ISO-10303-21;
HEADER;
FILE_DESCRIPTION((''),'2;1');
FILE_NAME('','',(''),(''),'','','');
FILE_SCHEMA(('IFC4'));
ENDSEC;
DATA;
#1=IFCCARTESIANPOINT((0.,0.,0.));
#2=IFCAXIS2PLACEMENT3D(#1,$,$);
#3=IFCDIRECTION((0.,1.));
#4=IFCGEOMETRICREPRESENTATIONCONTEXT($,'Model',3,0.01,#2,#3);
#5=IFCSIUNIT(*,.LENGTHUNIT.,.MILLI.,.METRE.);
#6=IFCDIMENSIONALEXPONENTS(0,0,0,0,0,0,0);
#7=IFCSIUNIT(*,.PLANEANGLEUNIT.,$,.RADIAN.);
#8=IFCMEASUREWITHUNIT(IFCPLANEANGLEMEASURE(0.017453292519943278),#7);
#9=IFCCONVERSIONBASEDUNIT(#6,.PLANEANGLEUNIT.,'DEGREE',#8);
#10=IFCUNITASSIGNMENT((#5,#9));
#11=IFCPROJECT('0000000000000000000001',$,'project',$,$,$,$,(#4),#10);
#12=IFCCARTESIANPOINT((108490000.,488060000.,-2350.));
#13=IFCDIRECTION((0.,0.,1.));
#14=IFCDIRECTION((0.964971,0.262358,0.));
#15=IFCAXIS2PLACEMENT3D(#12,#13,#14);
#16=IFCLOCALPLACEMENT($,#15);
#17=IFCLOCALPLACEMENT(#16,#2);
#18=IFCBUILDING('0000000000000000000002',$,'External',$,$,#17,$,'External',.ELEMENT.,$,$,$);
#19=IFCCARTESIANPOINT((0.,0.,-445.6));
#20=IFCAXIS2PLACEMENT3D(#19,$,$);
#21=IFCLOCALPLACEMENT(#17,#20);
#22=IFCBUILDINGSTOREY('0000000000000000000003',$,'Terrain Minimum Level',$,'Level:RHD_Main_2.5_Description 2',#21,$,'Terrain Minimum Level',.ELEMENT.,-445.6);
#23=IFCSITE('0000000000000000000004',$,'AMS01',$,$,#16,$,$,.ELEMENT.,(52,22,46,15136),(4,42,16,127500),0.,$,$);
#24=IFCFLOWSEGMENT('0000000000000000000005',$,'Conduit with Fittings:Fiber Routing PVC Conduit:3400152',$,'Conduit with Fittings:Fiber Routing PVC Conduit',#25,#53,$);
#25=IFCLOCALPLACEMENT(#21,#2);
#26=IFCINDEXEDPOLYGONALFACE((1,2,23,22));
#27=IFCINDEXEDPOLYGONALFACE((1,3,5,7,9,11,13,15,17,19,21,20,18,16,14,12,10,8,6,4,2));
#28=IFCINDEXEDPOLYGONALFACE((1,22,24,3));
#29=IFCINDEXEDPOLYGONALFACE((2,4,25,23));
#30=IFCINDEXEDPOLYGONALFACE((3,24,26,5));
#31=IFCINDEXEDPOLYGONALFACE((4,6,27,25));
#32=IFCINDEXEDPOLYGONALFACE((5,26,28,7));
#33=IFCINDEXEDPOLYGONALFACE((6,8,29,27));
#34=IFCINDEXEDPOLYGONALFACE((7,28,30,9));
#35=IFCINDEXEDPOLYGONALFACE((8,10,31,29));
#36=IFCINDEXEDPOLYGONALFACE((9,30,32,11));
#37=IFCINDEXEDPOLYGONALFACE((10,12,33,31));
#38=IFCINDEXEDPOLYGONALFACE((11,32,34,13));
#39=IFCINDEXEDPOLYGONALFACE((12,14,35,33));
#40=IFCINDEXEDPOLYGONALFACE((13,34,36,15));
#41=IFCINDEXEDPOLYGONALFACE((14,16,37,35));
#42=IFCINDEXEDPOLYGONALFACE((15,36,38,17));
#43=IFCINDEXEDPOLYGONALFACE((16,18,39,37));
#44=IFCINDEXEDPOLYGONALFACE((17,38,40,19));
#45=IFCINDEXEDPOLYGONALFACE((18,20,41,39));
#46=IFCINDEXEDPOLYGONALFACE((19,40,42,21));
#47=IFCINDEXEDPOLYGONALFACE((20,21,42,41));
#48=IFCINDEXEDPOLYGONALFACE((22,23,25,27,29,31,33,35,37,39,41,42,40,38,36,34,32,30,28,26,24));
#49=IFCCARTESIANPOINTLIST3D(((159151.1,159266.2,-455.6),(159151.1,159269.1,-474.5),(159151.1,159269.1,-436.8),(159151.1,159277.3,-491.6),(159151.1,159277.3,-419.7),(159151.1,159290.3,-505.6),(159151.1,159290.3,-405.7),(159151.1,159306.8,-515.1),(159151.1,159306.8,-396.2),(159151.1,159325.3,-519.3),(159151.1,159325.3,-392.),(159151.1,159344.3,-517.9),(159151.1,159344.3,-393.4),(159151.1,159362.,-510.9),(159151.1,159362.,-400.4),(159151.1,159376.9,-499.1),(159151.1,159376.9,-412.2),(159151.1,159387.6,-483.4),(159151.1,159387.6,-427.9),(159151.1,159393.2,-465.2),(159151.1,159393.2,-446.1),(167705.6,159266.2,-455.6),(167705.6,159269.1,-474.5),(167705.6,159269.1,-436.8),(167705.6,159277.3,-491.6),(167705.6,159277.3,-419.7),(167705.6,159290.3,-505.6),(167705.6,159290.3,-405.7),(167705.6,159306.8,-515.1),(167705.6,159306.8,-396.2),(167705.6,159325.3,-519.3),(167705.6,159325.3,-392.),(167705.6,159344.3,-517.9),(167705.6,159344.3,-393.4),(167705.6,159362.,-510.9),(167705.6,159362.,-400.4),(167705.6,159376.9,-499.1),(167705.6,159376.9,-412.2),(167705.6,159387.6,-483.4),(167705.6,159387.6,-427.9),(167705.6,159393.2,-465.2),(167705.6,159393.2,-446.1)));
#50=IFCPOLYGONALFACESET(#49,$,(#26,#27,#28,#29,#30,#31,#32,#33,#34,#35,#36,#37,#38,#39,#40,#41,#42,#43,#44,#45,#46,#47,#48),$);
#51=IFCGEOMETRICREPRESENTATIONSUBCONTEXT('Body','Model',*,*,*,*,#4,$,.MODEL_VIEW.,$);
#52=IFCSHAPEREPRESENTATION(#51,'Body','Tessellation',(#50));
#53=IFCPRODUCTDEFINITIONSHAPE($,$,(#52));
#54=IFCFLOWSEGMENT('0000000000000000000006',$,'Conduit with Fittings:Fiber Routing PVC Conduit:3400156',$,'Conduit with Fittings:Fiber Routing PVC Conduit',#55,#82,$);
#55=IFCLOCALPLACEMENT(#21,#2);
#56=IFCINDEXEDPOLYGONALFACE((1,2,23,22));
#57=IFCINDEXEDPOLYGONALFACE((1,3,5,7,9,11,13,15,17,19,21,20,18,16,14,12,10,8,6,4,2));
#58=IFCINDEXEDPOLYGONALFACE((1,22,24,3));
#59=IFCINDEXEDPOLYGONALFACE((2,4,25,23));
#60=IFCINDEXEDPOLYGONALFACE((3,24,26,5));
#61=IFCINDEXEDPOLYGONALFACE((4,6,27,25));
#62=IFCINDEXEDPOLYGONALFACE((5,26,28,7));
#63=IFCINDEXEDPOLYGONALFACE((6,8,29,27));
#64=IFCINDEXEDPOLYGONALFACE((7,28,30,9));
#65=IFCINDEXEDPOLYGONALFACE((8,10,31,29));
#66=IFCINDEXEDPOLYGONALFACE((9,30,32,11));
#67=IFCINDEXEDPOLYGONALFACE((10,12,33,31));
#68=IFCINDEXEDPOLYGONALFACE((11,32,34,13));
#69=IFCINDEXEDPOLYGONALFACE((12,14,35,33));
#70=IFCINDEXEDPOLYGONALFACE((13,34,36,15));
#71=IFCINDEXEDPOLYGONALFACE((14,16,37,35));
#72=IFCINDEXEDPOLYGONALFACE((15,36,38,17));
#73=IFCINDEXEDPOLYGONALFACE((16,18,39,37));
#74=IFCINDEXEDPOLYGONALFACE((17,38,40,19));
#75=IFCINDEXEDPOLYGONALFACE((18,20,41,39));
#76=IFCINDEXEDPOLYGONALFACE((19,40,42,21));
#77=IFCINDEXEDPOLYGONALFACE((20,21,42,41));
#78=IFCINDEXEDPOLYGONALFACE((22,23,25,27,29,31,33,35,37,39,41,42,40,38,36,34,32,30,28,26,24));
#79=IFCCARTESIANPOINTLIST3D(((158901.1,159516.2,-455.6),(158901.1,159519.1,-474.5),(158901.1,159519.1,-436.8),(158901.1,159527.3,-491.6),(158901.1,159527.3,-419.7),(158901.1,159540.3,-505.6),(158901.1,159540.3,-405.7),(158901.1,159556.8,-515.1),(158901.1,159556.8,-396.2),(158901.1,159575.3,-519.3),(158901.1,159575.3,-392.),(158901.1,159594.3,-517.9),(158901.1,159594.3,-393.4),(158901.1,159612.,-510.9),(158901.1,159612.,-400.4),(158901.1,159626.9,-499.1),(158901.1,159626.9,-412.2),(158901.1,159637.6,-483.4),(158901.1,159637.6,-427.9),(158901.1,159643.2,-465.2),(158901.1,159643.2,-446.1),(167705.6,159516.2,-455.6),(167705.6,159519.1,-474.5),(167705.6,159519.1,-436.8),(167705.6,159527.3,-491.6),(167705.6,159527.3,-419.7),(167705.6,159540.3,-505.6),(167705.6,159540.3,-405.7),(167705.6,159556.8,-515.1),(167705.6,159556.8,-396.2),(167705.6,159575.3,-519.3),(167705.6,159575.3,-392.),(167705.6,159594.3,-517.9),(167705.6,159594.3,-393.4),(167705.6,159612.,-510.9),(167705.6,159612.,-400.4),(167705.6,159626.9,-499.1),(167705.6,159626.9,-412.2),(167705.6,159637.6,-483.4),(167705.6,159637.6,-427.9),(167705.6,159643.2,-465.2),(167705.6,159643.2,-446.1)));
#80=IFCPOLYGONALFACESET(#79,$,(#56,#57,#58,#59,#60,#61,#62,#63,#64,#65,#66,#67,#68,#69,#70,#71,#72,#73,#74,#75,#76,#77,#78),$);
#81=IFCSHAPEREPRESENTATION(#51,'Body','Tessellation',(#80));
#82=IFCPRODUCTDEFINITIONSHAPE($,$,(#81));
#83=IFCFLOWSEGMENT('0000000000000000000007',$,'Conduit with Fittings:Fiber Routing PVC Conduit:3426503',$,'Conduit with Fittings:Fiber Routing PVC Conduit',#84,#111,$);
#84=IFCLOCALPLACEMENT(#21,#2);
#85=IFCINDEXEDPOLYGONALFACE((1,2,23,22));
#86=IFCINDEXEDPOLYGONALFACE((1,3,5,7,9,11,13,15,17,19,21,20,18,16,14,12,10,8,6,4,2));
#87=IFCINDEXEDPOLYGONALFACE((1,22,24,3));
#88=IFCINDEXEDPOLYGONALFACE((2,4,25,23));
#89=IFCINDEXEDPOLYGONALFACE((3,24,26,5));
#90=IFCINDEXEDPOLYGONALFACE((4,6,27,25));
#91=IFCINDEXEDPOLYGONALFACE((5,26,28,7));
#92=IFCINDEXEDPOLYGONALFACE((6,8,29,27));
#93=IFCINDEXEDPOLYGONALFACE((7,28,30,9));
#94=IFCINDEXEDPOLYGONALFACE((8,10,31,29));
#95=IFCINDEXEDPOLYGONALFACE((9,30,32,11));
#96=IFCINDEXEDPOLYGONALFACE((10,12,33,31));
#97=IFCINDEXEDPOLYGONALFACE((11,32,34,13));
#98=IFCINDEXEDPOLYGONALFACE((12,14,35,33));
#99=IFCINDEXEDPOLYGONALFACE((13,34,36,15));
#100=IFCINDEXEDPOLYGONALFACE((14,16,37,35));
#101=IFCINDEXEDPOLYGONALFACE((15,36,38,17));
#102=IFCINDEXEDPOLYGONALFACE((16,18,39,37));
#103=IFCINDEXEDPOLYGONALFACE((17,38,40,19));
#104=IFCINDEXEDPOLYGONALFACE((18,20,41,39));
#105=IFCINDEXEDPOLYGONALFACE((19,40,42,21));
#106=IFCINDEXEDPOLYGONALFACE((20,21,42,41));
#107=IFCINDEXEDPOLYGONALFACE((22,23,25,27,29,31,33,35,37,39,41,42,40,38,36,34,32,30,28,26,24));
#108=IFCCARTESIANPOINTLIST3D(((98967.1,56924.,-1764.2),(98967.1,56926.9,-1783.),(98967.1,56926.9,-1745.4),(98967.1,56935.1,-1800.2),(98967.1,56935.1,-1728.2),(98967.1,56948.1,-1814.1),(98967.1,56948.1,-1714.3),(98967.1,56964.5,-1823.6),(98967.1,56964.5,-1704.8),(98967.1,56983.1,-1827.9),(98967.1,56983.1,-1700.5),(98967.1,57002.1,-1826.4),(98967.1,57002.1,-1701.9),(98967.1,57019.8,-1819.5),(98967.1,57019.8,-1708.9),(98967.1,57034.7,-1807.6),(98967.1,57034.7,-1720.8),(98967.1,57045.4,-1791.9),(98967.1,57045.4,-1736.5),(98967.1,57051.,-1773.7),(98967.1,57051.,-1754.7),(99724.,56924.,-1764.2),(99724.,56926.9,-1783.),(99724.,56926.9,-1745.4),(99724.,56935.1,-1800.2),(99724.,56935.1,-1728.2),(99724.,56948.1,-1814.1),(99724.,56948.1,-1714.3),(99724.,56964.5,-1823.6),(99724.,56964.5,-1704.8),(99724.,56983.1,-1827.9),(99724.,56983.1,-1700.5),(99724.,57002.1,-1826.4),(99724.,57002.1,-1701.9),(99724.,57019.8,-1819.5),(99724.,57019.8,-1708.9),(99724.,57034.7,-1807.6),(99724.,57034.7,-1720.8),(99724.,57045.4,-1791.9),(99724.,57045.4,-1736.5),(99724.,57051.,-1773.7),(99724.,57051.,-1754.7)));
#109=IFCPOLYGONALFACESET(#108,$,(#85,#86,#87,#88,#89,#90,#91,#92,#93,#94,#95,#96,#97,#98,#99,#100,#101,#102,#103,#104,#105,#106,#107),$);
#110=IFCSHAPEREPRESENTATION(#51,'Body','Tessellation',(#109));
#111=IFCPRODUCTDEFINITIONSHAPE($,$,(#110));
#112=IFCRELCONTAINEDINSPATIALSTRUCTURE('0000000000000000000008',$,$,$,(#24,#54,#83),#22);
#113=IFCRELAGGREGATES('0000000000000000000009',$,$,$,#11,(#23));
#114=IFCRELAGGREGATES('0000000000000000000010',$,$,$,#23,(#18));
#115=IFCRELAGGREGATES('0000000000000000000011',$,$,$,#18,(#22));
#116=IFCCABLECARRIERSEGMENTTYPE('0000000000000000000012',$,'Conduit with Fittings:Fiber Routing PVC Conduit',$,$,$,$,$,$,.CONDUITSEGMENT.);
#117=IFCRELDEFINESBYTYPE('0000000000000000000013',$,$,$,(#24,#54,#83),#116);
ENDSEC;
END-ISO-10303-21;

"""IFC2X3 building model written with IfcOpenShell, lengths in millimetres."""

from ifc_helpers import new_model, entity, si_unit, converted_unit, direction, frame, origin, origin_2d_with_axis, place, context, subcontext, project, spatial, circle, extrude, type_object, element, save


model = new_model("IFC2X3")

# Units and contexts
model_context = context("Model", 3, precision=0.01, world=origin(), true_north=direction((0.0, 1.0)))
body_context = subcontext(model_context, "Body", "Model", "MODEL_VIEW")
ifc_project = project(units=[si_unit("LENGTHUNIT", "METRE", prefix="MILLI"), converted_unit("PLANEANGLEUNIT", "DEGREE", entity("IfcPlaneAngleMeasure", 0.017453292519943278), si_unit("PLANEANGLEUNIT", "RADIAN"), dimensions=[0, 0, 0, 0, 0, 0, 0])], contexts=[model_context])

# Site, building, storey
site_placement = place(None, frame((108490000.0, 488060000.0, -2350.0), z_axis=(0.0, 0.0, 1.0), x_axis=(0.964971, 0.262358, 0.0)))
site = spatial("IfcSite", under=ifc_project, at=site_placement, Name="AMS01", CompositionType="ELEMENT", RefLatitude=(52, 22, 46, 15136), RefLongitude=(4, 42, 16, 127500), RefElevation=0.0)
building_placement = place(site_placement, origin())
building = spatial("IfcBuilding", under=site, at=building_placement, Name="External", LongName="External", CompositionType="ELEMENT")
storey_placement = place(building_placement, frame((0.0, 0.0, -445.6)))
storey = spatial("IfcBuildingStorey", under=building, at=storey_placement, Name="Terrain Minimum Level", ObjectType="Level:RHD_Main_2.5_Description 2", LongName="Terrain Minimum Level", CompositionType="ELEMENT", Elevation=-445.6)

# Flow segments
cable_carrier_segment_type = type_object("IfcCableCarrierSegmentType", Name="Conduit with Fittings:Fiber Routing PVC Conduit", PredefinedType="CONDUITSEGMENT")
flow_segment_1_placement = place(storey_placement, origin())
element("IfcFlowSegment", 1, at=flow_segment_1_placement, inside=storey, type_object=cable_carrier_segment_type, Name="Conduit with Fittings:Fiber Routing PVC Conduit:3400152", ObjectType="Conduit with Fittings:Fiber Routing PVC Conduit", context=body_context, shape_type="SweptSolid", body=[
    extrude(circle(Radius=63.9, at=origin_2d_with_axis()), frame((159151.1, 159330.1, -455.6), z_axis=(1.0, 0.0, 0.0), x_axis=(0.0, -1.0, 0.0)), (0.0, 0.0, 1.0), 8554.6),
])
flow_segment_2_placement = place(storey_placement, origin())
element("IfcFlowSegment", 2, at=flow_segment_2_placement, inside=storey, type_object=cable_carrier_segment_type, Name="Conduit with Fittings:Fiber Routing PVC Conduit:3400156", ObjectType="Conduit with Fittings:Fiber Routing PVC Conduit", context=body_context, shape_type="SweptSolid", body=[
    extrude(circle(Radius=63.9, at=origin_2d_with_axis()), frame((158901.1, 159580.1, -455.6), z_axis=(1.0, 0.0, 0.0), x_axis=(0.0, -1.0, 0.0)), (0.0, 0.0, 1.0), 8804.6),
])
flow_segment_3_placement = place(storey_placement, origin())
element("IfcFlowSegment", 3, at=flow_segment_3_placement, inside=storey, type_object=cable_carrier_segment_type, Name="Conduit with Fittings:Fiber Routing PVC Conduit:3426503", ObjectType="Conduit with Fittings:Fiber Routing PVC Conduit", context=body_context, shape_type="SweptSolid", body=[
    extrude(circle(Radius=63.9, at=origin_2d_with_axis()), frame((98967.1, 56987.9, -1764.2), z_axis=(1.0, 0.0, 0.0), x_axis=(0.0, -1.0, 0.0)), (0.0, 0.0, 1.0), 756.9),
])

save(model, "model.ifc")
